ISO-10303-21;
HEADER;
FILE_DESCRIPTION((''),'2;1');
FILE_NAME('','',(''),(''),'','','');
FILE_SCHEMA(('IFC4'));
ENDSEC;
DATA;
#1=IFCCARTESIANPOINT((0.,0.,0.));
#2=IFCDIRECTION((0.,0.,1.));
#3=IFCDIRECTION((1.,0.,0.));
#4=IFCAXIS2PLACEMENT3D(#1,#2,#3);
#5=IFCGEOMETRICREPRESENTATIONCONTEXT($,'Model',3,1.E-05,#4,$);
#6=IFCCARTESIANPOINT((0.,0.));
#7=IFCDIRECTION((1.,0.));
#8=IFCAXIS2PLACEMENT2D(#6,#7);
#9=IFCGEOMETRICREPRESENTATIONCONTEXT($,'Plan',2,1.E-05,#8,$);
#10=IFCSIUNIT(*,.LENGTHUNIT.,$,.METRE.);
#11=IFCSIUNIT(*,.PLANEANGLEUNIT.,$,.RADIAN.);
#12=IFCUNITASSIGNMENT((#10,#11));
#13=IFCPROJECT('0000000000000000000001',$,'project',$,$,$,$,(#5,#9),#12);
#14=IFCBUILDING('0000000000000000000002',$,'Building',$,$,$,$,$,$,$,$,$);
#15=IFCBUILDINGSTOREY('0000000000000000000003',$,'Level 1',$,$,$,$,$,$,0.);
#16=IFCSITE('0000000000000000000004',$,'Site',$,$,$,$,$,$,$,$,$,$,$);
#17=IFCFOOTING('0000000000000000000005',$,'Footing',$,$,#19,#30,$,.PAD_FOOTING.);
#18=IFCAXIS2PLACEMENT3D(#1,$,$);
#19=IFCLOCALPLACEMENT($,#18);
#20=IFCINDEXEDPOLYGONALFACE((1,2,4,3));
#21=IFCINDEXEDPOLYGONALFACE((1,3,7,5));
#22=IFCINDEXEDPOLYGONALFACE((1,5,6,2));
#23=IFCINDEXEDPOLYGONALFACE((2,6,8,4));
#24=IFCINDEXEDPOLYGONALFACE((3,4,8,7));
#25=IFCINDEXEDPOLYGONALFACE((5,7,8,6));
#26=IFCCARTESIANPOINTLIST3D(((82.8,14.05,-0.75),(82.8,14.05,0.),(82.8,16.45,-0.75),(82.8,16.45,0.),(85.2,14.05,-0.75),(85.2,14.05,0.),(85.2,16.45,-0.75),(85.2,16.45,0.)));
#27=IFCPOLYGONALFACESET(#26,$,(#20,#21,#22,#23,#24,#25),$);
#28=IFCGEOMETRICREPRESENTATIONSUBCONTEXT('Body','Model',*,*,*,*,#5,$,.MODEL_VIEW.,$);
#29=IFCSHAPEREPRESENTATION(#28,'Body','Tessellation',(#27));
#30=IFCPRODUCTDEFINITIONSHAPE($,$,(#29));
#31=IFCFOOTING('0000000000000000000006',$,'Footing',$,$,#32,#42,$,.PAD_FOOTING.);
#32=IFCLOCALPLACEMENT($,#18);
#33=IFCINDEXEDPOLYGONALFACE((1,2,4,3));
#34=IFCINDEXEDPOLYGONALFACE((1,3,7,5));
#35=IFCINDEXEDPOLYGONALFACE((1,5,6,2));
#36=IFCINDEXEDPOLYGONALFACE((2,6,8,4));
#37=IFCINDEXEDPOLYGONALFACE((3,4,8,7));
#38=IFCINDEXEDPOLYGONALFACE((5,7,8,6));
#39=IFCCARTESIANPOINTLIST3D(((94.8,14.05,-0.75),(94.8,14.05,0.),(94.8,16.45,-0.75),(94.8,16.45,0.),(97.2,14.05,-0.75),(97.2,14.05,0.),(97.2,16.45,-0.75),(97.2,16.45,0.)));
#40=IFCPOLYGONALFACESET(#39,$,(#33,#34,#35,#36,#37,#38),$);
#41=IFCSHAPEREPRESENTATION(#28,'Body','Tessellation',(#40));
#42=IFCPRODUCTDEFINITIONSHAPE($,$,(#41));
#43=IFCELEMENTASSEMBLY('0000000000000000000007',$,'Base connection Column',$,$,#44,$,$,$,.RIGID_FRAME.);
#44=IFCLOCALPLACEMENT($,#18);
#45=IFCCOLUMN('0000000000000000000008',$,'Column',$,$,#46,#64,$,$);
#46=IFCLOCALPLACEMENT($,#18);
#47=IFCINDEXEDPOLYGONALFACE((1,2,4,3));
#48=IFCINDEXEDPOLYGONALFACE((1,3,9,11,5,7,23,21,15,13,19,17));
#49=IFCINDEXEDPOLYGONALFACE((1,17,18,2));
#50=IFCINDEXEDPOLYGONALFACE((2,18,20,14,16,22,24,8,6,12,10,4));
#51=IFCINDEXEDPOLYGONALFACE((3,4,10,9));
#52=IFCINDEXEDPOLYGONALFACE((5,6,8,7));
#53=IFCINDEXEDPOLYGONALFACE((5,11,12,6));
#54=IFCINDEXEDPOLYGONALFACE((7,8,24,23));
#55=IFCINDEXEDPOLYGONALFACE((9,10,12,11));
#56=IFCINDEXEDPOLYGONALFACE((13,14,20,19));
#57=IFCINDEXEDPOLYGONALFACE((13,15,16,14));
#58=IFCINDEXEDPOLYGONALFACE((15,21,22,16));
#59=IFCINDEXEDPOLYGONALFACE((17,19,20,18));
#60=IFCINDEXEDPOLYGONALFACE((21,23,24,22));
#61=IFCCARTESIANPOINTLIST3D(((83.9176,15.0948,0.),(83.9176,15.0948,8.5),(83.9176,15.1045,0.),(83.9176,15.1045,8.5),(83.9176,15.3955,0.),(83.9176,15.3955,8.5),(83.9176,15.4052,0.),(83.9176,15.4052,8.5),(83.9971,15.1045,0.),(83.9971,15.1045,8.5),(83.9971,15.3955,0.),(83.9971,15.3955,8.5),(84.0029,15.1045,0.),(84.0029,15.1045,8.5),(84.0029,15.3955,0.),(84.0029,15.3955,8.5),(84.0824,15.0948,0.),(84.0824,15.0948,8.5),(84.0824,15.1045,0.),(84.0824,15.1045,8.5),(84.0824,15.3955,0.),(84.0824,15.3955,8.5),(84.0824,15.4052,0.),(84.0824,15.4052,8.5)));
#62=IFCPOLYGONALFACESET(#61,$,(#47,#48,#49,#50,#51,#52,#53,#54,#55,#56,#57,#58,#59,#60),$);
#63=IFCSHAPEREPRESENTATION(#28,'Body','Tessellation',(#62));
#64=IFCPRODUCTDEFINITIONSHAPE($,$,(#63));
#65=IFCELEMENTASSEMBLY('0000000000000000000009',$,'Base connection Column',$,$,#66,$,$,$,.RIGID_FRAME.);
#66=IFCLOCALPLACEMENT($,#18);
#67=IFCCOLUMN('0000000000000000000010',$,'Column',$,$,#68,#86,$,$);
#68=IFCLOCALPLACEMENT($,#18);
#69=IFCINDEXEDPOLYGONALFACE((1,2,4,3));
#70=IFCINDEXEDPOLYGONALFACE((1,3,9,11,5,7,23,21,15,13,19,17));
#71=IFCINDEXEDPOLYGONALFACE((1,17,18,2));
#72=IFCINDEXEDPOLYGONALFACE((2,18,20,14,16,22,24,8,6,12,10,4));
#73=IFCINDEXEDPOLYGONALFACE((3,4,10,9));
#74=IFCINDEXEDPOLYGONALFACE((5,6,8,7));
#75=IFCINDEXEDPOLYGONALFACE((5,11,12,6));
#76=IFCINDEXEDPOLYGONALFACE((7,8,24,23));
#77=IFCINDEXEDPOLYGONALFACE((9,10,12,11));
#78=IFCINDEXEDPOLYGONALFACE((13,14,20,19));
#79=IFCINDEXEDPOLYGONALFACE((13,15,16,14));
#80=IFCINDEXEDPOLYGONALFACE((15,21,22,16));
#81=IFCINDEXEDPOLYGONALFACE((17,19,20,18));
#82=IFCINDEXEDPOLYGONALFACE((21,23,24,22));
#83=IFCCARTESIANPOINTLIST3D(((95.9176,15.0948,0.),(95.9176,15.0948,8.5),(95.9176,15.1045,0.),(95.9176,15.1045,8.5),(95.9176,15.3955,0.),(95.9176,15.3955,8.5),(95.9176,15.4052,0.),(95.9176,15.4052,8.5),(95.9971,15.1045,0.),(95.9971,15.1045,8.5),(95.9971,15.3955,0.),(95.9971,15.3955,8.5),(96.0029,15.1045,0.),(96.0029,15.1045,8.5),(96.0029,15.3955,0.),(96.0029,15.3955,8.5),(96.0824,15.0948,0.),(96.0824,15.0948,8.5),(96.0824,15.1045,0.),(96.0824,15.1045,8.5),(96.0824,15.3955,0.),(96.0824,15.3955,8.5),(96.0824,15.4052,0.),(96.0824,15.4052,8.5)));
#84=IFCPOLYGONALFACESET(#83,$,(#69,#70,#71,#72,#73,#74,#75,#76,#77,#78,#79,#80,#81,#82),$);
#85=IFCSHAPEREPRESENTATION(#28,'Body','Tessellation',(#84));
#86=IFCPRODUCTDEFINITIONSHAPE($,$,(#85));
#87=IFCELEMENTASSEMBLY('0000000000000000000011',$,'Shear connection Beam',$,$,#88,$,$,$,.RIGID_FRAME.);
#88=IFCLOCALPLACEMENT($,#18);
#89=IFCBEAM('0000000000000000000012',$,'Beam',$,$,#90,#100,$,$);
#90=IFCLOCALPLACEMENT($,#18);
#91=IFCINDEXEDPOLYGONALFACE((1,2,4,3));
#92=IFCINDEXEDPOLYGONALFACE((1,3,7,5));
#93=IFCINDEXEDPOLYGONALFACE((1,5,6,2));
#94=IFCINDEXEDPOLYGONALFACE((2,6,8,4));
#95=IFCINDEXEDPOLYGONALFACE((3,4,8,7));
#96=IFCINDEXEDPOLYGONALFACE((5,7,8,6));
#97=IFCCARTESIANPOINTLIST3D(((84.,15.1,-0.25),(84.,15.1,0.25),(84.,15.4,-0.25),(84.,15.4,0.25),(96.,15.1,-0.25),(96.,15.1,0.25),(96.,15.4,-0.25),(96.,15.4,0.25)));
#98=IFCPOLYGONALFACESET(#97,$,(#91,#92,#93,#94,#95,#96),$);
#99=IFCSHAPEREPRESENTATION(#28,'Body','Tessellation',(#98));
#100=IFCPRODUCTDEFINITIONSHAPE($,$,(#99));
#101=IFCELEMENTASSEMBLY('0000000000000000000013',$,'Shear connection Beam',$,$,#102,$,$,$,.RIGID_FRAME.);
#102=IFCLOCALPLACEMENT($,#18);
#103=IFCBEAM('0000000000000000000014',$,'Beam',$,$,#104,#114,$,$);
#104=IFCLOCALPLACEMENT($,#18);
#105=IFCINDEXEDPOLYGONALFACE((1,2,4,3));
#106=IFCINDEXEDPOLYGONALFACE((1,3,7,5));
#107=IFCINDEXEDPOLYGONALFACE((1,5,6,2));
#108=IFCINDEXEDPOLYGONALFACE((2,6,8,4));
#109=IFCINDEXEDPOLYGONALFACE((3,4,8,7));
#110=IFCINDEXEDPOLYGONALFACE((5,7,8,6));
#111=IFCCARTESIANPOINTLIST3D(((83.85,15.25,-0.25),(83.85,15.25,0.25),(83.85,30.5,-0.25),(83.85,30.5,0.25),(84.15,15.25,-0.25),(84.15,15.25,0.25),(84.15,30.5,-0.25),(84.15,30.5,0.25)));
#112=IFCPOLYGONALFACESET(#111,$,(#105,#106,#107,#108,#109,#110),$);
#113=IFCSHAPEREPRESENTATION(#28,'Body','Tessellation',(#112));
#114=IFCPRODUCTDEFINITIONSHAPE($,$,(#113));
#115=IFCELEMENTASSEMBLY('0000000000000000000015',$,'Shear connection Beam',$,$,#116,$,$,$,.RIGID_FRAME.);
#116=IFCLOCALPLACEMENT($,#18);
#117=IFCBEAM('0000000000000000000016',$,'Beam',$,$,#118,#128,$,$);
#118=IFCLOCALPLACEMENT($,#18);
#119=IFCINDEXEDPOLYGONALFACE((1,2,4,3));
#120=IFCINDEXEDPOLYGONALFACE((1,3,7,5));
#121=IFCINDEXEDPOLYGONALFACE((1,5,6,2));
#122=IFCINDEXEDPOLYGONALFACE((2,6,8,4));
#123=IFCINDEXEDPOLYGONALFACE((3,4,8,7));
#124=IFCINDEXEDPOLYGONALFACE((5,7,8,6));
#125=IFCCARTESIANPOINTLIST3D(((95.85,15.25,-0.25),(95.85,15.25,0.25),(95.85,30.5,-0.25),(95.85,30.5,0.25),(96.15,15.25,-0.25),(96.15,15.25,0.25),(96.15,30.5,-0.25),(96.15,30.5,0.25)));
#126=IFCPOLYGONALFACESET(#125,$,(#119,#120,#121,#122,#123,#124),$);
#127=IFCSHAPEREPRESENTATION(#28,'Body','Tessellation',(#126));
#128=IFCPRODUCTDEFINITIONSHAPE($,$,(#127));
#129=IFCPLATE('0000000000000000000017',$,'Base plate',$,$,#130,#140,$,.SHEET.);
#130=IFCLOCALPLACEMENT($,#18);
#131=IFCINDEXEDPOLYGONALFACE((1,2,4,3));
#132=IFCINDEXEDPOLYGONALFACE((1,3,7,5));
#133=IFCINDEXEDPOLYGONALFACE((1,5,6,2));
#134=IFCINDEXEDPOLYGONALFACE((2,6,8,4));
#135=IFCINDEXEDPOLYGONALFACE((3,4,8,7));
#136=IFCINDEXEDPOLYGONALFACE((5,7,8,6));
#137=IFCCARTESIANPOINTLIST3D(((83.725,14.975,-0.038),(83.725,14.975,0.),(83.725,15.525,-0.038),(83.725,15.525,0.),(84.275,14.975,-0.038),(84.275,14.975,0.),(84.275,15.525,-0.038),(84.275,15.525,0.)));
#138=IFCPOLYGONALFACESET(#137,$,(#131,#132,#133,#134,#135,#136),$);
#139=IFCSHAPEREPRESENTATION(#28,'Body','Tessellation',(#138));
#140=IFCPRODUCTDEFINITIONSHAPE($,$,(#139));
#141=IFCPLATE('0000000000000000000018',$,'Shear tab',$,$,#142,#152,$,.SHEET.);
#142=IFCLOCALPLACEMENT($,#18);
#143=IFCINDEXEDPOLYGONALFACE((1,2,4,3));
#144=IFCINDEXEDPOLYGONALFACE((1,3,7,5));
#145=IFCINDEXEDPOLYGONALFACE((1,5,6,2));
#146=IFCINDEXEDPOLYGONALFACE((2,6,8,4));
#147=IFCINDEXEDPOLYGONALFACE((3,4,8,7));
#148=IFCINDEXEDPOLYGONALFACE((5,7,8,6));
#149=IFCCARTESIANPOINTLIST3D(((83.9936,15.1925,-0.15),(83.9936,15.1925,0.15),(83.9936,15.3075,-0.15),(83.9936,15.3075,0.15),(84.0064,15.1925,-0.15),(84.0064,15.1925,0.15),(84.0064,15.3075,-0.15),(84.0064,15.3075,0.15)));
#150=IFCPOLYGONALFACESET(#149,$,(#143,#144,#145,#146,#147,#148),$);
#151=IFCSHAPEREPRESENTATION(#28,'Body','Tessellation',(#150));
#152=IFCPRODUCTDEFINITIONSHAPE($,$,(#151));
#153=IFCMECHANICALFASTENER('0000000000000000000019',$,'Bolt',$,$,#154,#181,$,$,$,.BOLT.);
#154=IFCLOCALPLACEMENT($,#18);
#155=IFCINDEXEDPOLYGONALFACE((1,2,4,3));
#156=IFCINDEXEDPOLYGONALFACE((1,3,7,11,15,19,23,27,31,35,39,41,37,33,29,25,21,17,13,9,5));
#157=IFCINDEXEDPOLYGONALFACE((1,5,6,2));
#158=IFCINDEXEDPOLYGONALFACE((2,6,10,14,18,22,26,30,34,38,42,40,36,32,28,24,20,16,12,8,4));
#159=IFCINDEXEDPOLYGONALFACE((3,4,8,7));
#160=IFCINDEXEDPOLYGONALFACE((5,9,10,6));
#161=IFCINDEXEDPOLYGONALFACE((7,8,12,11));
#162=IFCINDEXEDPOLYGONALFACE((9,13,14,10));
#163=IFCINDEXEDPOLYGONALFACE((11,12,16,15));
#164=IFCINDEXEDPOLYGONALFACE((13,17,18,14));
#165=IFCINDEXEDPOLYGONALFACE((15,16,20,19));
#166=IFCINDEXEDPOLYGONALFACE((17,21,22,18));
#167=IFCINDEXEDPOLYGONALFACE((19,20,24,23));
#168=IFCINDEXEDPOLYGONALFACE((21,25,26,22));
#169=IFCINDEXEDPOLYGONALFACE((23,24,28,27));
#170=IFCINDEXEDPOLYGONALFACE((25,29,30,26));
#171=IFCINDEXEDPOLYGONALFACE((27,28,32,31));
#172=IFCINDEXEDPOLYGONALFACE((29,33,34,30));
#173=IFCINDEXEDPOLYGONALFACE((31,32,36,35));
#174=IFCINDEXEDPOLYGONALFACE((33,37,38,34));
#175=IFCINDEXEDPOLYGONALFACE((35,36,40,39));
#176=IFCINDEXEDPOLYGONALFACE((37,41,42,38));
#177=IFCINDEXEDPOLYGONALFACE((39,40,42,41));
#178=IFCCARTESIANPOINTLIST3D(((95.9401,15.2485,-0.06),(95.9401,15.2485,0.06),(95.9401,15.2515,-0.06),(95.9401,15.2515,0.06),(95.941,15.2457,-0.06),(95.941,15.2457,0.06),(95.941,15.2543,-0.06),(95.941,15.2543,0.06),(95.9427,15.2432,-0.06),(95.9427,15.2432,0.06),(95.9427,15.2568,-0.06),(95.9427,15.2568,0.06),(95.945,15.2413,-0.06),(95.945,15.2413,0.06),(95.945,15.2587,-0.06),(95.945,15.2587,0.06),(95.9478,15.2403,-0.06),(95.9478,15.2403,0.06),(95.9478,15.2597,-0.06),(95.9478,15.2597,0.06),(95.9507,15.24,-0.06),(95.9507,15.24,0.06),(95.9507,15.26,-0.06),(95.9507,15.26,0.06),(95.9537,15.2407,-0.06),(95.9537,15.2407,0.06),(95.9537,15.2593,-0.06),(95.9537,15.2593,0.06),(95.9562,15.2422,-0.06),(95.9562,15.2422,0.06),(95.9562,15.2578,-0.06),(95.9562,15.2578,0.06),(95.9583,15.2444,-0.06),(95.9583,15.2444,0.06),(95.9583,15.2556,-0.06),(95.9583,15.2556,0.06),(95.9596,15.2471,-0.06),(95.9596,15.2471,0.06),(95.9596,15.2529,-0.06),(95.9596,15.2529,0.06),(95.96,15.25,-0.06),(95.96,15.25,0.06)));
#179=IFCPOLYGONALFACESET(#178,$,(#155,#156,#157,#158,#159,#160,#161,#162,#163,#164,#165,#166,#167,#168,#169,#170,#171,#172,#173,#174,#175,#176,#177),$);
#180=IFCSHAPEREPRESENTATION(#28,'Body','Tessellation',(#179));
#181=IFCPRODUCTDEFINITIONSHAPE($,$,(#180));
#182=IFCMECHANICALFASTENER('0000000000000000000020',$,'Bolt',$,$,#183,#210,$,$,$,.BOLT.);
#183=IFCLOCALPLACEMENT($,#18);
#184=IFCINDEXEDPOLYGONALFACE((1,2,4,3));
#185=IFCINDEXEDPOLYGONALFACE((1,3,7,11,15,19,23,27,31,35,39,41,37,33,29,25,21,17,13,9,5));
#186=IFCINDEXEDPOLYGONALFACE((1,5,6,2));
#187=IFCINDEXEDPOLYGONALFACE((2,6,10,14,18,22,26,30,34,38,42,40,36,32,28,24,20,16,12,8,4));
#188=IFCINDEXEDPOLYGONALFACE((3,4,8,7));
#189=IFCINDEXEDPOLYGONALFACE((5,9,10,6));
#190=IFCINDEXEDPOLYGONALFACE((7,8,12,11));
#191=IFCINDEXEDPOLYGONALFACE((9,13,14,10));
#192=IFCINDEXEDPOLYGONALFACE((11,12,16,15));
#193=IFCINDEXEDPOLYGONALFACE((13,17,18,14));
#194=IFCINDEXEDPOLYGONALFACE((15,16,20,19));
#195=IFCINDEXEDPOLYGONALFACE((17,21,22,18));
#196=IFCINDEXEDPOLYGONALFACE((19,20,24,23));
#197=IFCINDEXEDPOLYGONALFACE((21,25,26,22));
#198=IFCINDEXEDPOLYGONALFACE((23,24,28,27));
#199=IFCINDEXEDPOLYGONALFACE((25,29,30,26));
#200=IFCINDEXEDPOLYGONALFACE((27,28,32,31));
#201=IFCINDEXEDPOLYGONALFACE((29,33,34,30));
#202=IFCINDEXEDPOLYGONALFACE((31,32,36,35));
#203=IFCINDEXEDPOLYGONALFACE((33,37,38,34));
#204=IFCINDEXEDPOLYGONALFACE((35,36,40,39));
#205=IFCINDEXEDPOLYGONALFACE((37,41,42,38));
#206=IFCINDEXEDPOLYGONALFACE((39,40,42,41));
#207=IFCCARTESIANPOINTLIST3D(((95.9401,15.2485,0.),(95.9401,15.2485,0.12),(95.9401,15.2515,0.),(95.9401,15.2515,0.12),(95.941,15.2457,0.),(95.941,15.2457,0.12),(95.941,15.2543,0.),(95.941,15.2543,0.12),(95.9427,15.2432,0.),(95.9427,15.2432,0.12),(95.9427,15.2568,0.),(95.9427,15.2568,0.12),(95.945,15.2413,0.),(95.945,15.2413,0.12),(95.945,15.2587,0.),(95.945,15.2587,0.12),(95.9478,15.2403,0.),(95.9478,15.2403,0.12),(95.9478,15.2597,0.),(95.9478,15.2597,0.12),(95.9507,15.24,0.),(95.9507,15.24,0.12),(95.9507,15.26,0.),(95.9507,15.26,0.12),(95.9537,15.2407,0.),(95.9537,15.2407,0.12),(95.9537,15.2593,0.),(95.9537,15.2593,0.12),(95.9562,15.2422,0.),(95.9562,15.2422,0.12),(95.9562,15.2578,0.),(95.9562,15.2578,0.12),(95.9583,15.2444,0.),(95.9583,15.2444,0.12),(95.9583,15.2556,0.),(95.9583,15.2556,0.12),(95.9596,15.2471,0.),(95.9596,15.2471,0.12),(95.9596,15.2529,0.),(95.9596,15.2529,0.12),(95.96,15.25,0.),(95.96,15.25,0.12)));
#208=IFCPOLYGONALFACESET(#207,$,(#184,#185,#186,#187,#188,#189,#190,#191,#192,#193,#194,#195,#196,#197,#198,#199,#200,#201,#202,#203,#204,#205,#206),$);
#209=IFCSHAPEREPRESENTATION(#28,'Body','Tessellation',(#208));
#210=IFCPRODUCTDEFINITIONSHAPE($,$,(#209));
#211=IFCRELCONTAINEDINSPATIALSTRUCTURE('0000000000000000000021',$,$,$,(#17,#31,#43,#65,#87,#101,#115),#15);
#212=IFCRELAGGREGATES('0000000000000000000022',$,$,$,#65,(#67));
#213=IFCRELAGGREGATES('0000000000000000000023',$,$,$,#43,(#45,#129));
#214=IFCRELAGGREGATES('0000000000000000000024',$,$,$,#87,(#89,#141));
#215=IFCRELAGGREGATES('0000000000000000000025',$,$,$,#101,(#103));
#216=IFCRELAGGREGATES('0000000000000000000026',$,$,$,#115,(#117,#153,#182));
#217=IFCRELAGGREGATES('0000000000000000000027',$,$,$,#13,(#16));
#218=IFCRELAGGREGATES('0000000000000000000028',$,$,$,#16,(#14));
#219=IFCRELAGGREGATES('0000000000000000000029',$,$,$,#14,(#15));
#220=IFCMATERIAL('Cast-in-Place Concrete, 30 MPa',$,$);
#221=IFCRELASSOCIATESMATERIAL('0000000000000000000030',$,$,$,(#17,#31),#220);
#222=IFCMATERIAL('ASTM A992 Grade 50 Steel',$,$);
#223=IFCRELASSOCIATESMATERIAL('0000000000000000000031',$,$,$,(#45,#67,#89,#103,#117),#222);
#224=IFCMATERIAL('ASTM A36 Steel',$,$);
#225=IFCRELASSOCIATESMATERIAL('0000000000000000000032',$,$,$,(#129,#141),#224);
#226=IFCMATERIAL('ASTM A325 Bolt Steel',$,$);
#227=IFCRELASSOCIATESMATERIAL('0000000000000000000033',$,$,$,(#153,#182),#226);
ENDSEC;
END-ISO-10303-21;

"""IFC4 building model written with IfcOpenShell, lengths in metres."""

from ifc_helpers import new_model, si_unit, frame, origin_with_axes, origin_2d, origin_2d_with_axis, place, context, subcontext, project, spatial, rectangle, circle, i_section, extrude, material, element, aggregate, save


model = new_model("IFC4")

# Units and contexts
model_context = context("Model", 3, precision=1e-05, world=origin_with_axes())
plan_context = context("Plan", 2, precision=1e-05, world=origin_2d_with_axis())
body_context = subcontext(model_context, "Body", "Model", "MODEL_VIEW")
ifc_project = project(units=[si_unit("LENGTHUNIT", "METRE"), si_unit("PLANEANGLEUNIT", "RADIAN")], contexts=[model_context, plan_context])

# Site, building, storey
site = spatial("IfcSite", under=ifc_project, Name="Site")
building = spatial("IfcBuilding", under=site, Name="Building")
storey = spatial("IfcBuildingStorey", under=building, Name="Level 1", Elevation=0.0)

# Footings
ifc_material_1 = material(Name="Cast-in-Place Concrete, 30 MPa")
for number, where, z_axis, x_axis, name in (
    (1, (84.0, 15.25, -0.75), (0.0, 0.0, 1.0), (1.0, 0.0, 0.0), "Footing"),
    (2, (96.0, 15.25, -0.75), (0.0, 0.0, 1.0), (1.0, 0.0, 0.0), "Footing"),
):
    element("IfcFooting", number, at=place(None, frame(where, z_axis=z_axis, x_axis=x_axis)), inside=storey, material=ifc_material_1, Name=name, PredefinedType="PAD_FOOTING", context=body_context, shape_type="SweptSolid", body=[
        extrude(rectangle(XDim=2.4, YDim=2.4, at=origin_2d_with_axis()), origin_with_axes(), (0.0, 0.0, 1.0), 0.75),
    ])

# Element assemblies, columns
assembly_1 = element("IfcElementAssembly", 3, inside=storey, Name="Base connection Column", PredefinedType="RIGID_FRAME")
ifc_material_2 = material(Name="ASTM A992 Grade 50 Steel")
column_1_placement = place(None, frame((84.0, 15.25, 0.0), z_axis=(0.0, 0.0, 1.0), x_axis=(1.0, 0.0, 0.0)))
column_1 = element("IfcColumn", 4, at=column_1_placement, material=ifc_material_2, Name="Column", context=body_context, shape_type="SweptSolid", body=[
    extrude(i_section(OverallWidth=0.1648, OverallDepth=0.3104, WebThickness=0.0058, FlangeThickness=0.0097, at=origin_2d_with_axis()), origin_with_axes(), (0.0, 0.0, 1.0), 8.5),
])
assembly_2 = element("IfcElementAssembly", 5, inside=storey, Name="Base connection Column", PredefinedType="RIGID_FRAME")
column_2_placement = place(None, frame((96.0, 15.25, 0.0), z_axis=(0.0, 0.0, 1.0), x_axis=(1.0, 0.0, 0.0)))
column_2 = element("IfcColumn", 6, at=column_2_placement, material=ifc_material_2, Name="Column", context=body_context, shape_type="SweptSolid", body=[
    extrude(i_section(OverallWidth=0.1648, OverallDepth=0.3104, WebThickness=0.0058, FlangeThickness=0.0097, at=origin_2d_with_axis()), origin_with_axes(), (0.0, 0.0, 1.0), 8.5),
])
aggregate(assembly_2, [column_2])

# Element assemblies, beams
assembly_3 = element("IfcElementAssembly", 7, inside=storey, Name="Shear connection Beam", PredefinedType="RIGID_FRAME")
beam_1_placement = place(None, frame((84.0, 15.25, 0.0), z_axis=(1.0, 0.0, 0.0), x_axis=(0.0, 1.0, 0.0)))
beam_1 = element("IfcBeam", 8, at=beam_1_placement, material=ifc_material_2, Name="Beam", context=body_context, shape_type="SweptSolid", body=[
    extrude(rectangle(XDim=0.3, YDim=0.5, at=origin_2d_with_axis()), origin_with_axes(), (0.0, 0.0, 1.0), 12.0),
])
assembly_4 = element("IfcElementAssembly", 9, inside=storey, Name="Shear connection Beam", PredefinedType="RIGID_FRAME")
beam_2_placement = place(None, frame((84.0, 15.25, 0.0), z_axis=(0.0, 1.0, 0.0), x_axis=(-1.0, 0.0, 0.0)))
beam_2 = element("IfcBeam", 10, at=beam_2_placement, material=ifc_material_2, Name="Beam", context=body_context, shape_type="SweptSolid", body=[
    extrude(rectangle(XDim=0.3, YDim=0.5, at=origin_2d_with_axis()), origin_with_axes(), (0.0, 0.0, 1.0), 15.25),
])
assembly_5 = element("IfcElementAssembly", 11, inside=storey, Name="Shear connection Beam", PredefinedType="RIGID_FRAME")
beam_3_placement = place(None, frame((96.0, 15.25, 0.0), z_axis=(0.0, 1.0, 0.0), x_axis=(-1.0, 0.0, 0.0)))
beam_3 = element("IfcBeam", 12, at=beam_3_placement, material=ifc_material_2, Name="Beam", context=body_context, shape_type="SweptSolid", body=[
    extrude(rectangle(XDim=0.3, YDim=0.5, at=origin_2d_with_axis()), origin_with_axes(), (0.0, 0.0, 1.0), 15.25),
])

# Plates
ifc_material_3 = material(Name="ASTM A36 Steel")
plate_1_placement = place(None, frame((84.0, 15.25, -0.038), z_axis=(0.0, 0.0, 1.0), x_axis=(1.0, 0.0, 0.0)))
plate_1 = element("IfcPlate", 13, at=plate_1_placement, material=ifc_material_3, Name="Base plate", PredefinedType="SHEET", context=body_context, shape_type="SweptSolid", body=[
    extrude(rectangle(XDim=0.55, YDim=0.55, at=origin_2d_with_axis()), origin_with_axes(), (0.0, 0.0, 1.0), 0.038),
])
aggregate(assembly_1, [column_1, plate_1])
plate_2_placement = place(None, frame((84.0, 15.25, -0.15), z_axis=(0.0, 0.0, 1.0), x_axis=(1.0, 0.0, 0.0)))
plate_2 = element("IfcPlate", 14, at=plate_2_placement, material=ifc_material_3, Name="Shear tab", PredefinedType="SHEET", context=body_context, shape_type="SweptSolid", body=[
    extrude(rectangle(XDim=0.0127, YDim=0.115, at=origin_2d_with_axis()), origin_with_axes(), (0.0, 0.0, 1.0), 0.3),
])
aggregate(assembly_3, [beam_1, plate_2])
aggregate(assembly_4, [beam_2])

# Mechanical fasteners
ifc_material_4 = material(Name="ASTM A325 Bolt Steel")
mechanical_fastener_1_placement = place(None, frame((95.95, 15.25, -0.06), z_axis=(0.0, 0.0, 1.0), x_axis=(1.0, 0.0, 0.0)))
mechanical_fastener_1 = element("IfcMechanicalFastener", 15, at=mechanical_fastener_1_placement, material=ifc_material_4, Name="Bolt", PredefinedType="BOLT", context=body_context, shape_type="SweptSolid", body=[
    extrude(circle(Radius=0.01, at=origin_2d()), origin_with_axes(), (0.0, 0.0, 1.0), 0.12),
])
mechanical_fastener_2_placement = place(None, frame((95.95, 15.25, 0.0), z_axis=(0.0, 0.0, 1.0), x_axis=(1.0, 0.0, 0.0)))
mechanical_fastener_2 = element("IfcMechanicalFastener", 16, at=mechanical_fastener_2_placement, material=ifc_material_4, Name="Bolt", PredefinedType="BOLT", context=body_context, shape_type="SweptSolid", body=[
    extrude(circle(Radius=0.01, at=origin_2d()), origin_with_axes(), (0.0, 0.0, 1.0), 0.12),
])
aggregate(assembly_5, [beam_3, mechanical_fastener_1, mechanical_fastener_2])

save(model, "model.ifc")
